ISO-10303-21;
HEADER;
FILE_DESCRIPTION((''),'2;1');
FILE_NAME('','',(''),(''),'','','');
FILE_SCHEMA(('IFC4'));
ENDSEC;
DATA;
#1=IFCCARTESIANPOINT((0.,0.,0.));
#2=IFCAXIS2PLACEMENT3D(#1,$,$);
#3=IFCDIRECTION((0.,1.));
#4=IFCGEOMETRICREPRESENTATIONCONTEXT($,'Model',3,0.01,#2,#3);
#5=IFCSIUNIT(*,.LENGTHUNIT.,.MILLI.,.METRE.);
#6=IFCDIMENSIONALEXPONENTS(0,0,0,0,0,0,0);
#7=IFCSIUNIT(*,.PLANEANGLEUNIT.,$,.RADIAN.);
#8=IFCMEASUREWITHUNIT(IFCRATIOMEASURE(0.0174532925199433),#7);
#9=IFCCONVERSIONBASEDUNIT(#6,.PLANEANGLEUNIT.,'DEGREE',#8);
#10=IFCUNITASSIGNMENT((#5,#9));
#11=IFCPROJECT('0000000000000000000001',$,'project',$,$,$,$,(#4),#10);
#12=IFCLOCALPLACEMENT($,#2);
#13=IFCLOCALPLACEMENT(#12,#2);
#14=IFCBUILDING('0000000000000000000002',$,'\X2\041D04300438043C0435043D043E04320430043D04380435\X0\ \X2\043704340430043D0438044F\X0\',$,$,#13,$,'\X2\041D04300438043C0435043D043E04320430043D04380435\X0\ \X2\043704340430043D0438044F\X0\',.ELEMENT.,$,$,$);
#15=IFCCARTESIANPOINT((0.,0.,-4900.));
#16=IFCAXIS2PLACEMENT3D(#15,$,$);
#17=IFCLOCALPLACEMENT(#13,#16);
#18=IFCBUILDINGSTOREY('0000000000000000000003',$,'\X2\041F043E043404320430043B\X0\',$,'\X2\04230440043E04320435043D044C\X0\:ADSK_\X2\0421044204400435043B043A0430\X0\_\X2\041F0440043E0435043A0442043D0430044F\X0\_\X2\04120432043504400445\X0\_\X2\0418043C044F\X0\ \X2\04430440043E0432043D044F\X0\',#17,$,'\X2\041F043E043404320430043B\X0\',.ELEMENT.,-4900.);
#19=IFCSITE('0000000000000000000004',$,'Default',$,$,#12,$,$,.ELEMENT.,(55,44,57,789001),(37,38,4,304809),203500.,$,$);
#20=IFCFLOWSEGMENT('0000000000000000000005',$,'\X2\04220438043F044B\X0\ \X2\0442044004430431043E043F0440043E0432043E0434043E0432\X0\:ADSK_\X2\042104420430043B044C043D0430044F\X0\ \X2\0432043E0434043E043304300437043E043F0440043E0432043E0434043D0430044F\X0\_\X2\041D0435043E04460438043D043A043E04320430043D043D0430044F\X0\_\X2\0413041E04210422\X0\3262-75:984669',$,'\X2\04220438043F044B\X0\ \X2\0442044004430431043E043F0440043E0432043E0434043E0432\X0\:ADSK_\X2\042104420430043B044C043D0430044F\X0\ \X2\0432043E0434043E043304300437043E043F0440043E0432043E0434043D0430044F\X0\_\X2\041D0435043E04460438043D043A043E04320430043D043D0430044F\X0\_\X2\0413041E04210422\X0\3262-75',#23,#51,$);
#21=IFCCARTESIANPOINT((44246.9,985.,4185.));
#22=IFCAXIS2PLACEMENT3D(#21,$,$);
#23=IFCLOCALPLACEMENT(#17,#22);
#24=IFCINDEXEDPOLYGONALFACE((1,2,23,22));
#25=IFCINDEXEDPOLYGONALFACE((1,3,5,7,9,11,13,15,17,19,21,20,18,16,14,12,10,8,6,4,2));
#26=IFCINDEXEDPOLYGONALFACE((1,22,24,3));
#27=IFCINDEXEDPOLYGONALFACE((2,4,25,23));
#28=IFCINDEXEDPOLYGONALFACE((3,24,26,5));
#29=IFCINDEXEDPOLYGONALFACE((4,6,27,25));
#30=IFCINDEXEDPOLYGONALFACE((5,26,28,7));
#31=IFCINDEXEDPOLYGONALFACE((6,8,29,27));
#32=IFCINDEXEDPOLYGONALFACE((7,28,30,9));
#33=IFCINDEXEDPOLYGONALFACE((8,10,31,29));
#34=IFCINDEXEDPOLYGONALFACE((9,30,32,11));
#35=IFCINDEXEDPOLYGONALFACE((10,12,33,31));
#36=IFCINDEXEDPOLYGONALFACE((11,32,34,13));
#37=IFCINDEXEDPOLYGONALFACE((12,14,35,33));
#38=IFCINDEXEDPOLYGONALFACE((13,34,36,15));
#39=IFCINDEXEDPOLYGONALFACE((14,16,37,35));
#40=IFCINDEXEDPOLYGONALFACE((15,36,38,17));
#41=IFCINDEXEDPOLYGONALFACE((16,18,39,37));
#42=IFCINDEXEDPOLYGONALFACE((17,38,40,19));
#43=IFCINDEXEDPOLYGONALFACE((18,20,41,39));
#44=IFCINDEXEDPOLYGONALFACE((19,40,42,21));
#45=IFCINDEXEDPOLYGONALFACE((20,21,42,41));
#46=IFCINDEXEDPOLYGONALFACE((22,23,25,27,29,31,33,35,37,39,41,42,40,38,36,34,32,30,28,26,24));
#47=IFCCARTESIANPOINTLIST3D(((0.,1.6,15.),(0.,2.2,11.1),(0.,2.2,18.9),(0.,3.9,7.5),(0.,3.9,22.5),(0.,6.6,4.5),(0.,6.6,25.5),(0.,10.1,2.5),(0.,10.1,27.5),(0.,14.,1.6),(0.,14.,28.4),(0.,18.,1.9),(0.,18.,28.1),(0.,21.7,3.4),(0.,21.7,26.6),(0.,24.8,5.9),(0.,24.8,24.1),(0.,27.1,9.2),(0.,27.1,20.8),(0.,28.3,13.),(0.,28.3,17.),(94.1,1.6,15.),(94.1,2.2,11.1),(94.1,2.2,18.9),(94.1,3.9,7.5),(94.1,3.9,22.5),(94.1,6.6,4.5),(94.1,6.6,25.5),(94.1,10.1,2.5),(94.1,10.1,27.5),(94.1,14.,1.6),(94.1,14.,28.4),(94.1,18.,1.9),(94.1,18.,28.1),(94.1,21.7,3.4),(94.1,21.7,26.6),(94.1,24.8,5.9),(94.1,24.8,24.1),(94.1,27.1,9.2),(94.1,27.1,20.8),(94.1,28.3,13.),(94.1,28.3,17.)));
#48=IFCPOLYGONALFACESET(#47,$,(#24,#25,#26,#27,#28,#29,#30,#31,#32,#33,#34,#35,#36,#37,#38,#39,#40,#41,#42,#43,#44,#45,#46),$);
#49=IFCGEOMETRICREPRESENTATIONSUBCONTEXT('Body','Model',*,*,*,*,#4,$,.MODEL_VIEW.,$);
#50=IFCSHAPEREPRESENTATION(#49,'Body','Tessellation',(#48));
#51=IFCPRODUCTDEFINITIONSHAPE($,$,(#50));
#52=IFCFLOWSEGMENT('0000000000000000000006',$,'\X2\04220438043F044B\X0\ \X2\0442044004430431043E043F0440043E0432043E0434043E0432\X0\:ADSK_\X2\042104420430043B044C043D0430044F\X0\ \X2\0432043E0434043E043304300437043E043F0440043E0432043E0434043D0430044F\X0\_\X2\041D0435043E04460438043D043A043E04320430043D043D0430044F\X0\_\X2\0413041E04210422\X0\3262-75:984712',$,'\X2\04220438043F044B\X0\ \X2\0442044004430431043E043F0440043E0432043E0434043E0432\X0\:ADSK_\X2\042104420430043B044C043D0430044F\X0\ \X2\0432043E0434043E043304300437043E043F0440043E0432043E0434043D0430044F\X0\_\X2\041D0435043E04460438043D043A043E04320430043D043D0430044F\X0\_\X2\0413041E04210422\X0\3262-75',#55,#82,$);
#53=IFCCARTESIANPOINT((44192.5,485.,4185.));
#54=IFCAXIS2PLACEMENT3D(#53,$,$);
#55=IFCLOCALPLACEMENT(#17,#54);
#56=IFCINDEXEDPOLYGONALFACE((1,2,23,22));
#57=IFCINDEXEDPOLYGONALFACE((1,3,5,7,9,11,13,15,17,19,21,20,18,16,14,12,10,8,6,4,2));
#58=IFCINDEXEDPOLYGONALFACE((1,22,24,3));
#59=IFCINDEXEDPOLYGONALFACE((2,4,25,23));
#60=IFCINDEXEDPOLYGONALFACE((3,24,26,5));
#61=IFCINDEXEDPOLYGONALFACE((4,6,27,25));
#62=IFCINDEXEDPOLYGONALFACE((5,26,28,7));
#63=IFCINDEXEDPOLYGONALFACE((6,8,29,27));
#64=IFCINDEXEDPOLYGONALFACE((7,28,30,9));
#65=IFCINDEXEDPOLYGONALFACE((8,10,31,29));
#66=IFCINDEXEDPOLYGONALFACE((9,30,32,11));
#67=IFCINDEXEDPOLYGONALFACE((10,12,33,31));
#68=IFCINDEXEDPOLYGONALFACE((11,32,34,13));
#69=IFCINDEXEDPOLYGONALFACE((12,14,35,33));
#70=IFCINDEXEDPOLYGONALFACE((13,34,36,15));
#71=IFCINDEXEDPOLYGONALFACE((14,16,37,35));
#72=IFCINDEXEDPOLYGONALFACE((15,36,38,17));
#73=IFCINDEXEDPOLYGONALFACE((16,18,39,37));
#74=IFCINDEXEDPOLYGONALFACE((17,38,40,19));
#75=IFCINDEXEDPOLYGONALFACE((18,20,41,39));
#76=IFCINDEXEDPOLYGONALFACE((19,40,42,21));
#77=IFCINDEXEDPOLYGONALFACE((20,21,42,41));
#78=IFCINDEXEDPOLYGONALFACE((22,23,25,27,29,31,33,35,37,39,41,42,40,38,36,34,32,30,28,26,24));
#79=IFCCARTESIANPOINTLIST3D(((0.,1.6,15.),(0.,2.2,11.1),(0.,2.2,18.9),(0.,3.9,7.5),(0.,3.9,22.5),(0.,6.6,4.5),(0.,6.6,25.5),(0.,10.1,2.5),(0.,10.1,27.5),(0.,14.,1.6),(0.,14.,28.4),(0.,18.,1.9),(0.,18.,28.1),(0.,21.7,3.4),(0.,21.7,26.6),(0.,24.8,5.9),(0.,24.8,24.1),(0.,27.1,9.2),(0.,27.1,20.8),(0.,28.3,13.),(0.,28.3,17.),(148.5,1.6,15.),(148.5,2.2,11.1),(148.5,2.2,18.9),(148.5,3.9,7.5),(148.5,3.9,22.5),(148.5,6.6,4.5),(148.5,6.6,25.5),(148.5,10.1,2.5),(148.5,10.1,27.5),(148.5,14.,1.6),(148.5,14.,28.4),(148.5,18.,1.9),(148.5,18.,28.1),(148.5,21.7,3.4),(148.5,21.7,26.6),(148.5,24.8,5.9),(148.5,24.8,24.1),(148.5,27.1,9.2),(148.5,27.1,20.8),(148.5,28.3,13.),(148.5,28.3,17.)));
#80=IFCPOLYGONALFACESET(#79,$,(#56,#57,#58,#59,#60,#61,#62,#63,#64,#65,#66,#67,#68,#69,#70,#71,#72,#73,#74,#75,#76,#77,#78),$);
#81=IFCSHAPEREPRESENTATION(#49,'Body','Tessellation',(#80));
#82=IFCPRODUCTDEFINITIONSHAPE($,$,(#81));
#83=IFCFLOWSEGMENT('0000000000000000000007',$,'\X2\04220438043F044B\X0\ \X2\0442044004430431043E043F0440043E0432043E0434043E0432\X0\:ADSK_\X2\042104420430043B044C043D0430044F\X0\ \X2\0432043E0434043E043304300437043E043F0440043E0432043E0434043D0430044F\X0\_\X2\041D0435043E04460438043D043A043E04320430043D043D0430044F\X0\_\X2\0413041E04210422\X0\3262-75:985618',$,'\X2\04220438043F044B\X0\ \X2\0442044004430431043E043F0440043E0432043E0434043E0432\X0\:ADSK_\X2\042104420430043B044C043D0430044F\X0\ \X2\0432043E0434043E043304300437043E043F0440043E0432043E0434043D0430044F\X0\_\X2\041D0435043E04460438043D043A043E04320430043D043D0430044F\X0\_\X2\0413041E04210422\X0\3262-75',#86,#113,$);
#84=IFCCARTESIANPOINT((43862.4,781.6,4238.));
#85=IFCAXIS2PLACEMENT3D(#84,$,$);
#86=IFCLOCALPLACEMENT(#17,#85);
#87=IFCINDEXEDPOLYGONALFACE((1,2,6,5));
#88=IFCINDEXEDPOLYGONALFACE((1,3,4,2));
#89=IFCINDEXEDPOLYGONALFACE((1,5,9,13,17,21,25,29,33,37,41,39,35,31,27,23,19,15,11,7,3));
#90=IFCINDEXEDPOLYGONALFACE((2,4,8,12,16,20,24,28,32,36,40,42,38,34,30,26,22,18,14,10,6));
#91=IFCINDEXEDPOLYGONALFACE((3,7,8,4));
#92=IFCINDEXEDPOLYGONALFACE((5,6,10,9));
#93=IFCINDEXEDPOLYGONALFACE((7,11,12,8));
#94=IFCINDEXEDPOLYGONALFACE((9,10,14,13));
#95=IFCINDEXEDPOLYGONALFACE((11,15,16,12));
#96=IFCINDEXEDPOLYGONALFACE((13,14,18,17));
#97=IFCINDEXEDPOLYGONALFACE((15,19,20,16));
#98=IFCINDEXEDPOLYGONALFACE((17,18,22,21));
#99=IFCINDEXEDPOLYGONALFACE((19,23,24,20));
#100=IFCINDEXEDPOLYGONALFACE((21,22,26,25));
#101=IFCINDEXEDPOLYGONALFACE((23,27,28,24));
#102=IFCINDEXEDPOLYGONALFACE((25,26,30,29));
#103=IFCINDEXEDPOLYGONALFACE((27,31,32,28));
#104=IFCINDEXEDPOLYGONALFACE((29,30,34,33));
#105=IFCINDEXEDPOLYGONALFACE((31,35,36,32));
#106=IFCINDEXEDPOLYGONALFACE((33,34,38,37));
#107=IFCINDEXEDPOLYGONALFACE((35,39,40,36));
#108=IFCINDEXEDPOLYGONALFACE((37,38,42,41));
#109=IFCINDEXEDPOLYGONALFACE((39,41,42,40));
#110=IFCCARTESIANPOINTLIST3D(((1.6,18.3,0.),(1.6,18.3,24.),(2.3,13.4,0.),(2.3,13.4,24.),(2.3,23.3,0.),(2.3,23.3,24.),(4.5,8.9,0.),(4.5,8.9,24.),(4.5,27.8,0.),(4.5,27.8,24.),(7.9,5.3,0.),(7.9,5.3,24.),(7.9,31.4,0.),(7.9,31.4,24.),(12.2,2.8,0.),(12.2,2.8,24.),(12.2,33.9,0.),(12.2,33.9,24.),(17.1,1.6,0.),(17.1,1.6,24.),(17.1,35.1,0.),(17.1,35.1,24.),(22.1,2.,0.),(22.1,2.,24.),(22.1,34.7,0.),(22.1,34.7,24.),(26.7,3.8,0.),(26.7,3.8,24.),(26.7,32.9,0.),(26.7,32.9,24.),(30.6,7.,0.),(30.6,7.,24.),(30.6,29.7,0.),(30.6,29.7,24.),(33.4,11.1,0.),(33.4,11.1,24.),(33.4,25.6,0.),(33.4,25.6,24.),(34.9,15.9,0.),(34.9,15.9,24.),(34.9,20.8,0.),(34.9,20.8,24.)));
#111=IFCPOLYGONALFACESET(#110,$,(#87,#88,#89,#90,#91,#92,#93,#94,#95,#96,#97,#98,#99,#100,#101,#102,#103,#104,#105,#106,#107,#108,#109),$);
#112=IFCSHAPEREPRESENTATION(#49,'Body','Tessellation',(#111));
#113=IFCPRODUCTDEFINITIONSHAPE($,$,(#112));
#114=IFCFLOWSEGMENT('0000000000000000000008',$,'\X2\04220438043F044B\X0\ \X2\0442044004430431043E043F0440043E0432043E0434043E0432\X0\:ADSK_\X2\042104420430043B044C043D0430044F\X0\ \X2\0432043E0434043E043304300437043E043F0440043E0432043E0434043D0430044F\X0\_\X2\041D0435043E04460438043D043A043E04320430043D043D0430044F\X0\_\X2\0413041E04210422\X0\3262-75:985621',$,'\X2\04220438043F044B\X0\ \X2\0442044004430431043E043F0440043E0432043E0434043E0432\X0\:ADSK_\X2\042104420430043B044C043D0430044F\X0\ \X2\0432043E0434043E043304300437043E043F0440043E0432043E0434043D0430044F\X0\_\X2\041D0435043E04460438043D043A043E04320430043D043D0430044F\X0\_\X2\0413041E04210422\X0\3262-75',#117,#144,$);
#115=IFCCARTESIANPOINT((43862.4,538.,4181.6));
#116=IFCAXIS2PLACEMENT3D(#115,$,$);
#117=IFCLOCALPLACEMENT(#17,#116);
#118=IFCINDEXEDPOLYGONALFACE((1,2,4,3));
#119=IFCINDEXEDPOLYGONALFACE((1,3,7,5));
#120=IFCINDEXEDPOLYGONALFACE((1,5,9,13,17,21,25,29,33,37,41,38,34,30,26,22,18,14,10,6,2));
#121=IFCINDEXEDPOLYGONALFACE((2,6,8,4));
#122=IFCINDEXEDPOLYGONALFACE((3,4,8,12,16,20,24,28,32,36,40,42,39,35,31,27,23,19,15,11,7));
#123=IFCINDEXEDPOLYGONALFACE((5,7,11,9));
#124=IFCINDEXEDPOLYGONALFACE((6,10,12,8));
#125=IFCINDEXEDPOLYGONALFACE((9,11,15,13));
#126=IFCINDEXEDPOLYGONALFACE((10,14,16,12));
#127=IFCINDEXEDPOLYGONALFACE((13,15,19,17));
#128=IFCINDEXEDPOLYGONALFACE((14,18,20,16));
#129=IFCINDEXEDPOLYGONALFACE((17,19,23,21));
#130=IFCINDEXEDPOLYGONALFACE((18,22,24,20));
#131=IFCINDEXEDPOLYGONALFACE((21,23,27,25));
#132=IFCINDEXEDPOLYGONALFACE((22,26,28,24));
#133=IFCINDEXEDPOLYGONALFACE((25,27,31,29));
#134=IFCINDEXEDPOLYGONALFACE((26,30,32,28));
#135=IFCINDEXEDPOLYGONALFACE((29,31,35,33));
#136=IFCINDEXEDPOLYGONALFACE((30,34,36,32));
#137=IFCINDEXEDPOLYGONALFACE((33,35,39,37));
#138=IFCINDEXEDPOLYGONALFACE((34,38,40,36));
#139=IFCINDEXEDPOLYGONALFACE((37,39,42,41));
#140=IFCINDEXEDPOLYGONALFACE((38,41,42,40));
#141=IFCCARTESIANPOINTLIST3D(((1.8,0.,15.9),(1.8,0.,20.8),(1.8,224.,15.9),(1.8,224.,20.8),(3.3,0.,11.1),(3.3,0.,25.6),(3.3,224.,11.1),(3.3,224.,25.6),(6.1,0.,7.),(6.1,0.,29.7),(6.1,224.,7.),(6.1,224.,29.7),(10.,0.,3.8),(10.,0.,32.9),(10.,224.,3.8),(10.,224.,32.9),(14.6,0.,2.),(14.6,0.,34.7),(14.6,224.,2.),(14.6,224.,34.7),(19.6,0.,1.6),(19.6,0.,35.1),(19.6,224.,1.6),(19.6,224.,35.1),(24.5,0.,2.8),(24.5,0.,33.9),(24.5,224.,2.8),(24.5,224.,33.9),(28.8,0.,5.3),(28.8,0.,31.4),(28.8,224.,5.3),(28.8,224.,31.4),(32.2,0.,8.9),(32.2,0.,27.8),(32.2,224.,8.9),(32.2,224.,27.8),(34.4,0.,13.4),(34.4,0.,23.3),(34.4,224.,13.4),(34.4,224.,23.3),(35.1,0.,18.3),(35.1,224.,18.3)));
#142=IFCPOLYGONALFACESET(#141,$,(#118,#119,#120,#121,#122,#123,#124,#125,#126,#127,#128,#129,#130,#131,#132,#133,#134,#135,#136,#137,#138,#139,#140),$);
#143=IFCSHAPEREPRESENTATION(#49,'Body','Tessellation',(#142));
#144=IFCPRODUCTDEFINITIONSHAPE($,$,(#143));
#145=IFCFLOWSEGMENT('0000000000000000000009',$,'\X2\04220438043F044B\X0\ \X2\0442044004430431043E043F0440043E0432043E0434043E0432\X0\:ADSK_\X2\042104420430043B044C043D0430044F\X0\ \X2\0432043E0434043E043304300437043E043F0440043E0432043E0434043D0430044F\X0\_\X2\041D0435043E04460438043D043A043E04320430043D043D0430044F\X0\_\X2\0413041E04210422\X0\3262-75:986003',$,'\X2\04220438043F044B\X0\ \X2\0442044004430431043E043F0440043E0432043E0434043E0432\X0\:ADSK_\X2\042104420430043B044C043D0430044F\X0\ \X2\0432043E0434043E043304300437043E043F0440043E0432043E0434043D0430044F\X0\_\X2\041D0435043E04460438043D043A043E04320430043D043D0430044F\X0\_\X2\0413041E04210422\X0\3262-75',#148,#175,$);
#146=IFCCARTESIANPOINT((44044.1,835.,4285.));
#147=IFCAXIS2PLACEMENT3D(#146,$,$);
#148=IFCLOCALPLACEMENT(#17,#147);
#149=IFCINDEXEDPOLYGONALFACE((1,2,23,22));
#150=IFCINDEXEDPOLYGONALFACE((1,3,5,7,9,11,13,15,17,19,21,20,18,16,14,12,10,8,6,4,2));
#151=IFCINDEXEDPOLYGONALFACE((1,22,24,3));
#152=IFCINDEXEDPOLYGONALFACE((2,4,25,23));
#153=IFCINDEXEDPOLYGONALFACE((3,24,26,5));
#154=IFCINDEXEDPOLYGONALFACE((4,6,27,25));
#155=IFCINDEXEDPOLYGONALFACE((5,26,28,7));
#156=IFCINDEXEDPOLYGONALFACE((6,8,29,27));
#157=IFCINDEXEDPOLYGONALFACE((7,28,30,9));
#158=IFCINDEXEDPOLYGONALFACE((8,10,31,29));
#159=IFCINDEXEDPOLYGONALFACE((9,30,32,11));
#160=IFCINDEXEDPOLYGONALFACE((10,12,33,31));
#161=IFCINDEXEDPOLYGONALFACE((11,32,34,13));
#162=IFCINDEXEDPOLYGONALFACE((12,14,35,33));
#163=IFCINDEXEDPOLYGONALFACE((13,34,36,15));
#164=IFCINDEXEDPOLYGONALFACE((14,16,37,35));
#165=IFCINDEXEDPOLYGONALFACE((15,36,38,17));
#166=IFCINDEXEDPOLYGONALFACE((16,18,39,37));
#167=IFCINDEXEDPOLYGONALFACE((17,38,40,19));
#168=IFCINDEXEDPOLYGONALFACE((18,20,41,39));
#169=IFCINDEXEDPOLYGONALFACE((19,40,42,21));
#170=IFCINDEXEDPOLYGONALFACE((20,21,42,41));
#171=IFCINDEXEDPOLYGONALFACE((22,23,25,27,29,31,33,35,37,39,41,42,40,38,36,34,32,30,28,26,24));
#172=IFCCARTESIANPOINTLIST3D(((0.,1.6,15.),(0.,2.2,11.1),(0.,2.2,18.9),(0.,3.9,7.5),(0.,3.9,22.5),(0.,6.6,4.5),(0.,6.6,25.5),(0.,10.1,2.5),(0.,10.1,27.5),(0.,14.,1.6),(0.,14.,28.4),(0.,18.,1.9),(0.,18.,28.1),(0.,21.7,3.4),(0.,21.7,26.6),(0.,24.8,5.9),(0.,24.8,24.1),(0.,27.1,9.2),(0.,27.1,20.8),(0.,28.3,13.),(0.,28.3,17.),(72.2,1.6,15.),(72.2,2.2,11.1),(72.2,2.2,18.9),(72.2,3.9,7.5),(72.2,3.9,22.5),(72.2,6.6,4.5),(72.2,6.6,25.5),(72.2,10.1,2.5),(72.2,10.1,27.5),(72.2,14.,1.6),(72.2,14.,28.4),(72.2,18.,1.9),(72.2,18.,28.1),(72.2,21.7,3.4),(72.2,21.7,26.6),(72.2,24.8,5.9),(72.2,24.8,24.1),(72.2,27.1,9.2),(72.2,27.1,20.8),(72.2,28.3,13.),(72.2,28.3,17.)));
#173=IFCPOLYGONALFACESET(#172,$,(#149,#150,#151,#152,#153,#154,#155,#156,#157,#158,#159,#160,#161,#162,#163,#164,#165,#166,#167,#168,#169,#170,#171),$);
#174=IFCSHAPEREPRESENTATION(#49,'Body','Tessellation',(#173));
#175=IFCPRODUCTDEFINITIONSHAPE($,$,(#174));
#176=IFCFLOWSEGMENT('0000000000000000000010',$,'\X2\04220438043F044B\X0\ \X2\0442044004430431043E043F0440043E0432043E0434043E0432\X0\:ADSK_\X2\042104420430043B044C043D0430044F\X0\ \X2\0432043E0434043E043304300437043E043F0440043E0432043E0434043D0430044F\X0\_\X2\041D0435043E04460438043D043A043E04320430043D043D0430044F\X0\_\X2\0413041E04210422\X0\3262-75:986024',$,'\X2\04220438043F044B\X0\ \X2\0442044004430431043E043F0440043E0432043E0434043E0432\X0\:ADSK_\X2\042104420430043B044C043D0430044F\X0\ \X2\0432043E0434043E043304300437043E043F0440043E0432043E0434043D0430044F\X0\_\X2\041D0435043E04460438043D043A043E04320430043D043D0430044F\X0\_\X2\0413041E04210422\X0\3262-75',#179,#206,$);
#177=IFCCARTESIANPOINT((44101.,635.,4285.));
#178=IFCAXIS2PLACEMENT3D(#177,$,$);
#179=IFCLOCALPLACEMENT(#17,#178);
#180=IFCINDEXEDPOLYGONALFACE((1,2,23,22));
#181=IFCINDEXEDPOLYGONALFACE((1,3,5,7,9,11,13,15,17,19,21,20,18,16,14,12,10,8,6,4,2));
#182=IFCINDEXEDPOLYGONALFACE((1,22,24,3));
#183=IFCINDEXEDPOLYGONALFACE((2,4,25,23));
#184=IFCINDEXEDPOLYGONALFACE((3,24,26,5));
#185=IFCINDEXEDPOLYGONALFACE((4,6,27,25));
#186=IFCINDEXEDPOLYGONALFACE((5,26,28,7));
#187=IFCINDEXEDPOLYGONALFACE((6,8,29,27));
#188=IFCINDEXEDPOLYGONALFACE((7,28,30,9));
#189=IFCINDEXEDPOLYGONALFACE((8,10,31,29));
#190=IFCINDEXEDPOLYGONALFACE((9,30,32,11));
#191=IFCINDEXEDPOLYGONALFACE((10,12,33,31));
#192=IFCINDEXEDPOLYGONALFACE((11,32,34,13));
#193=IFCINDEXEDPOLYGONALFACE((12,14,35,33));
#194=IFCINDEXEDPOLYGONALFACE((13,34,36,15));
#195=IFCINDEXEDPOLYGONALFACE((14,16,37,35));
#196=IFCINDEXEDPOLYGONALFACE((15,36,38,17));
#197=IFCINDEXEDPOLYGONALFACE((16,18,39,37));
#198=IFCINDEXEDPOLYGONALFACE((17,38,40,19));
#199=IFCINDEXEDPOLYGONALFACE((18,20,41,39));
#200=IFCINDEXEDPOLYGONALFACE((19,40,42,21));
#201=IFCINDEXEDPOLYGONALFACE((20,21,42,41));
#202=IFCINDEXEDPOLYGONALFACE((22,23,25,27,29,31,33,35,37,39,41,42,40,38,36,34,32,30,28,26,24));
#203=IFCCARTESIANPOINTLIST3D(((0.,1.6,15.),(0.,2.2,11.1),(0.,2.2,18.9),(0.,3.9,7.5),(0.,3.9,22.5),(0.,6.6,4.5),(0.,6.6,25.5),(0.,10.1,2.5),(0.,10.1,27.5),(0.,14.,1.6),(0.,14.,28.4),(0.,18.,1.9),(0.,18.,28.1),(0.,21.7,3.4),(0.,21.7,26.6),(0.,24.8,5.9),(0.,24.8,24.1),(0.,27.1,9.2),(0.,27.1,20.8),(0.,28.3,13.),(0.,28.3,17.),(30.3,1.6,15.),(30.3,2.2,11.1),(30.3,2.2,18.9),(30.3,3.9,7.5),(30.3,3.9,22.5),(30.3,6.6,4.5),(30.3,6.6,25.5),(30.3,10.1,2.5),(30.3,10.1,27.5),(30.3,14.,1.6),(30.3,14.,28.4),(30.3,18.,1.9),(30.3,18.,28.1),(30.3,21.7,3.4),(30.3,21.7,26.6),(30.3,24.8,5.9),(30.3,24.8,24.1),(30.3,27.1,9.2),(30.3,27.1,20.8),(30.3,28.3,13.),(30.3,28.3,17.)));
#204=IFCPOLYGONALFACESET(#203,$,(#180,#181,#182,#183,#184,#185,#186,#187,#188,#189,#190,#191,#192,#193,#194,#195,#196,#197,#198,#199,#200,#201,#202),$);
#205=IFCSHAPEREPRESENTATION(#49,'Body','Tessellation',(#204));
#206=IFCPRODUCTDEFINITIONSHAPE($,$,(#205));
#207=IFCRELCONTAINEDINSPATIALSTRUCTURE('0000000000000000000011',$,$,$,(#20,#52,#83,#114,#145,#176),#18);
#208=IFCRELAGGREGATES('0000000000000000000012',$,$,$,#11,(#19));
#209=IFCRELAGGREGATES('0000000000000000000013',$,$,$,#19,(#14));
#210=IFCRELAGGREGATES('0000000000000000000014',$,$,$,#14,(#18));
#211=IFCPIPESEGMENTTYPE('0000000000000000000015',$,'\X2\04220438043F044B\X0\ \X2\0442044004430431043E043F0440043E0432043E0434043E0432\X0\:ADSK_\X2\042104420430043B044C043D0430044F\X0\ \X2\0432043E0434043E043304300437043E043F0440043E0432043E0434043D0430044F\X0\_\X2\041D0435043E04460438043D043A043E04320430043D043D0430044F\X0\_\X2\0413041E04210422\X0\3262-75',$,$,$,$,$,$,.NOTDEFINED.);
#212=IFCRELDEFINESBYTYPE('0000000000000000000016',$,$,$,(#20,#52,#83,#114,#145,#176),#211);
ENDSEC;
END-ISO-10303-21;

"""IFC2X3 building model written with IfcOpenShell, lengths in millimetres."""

from ifc_helpers import new_model, entity, si_unit, converted_unit, direction, frame, origin, origin_2d_with_axis, place, context, subcontext, project, spatial, circle, extrude, type_object, element, save


model = new_model("IFC2X3")

# Units and contexts
model_context = context("Model", 3, precision=0.01, world=origin(), true_north=direction((0.0, 1.0)))
body_context = subcontext(model_context, "Body", "Model", "MODEL_VIEW")
ifc_project = project(units=[si_unit("LENGTHUNIT", "METRE", prefix="MILLI"), converted_unit("PLANEANGLEUNIT", "DEGREE", entity("IfcRatioMeasure", 0.0174532925199433), si_unit("PLANEANGLEUNIT", "RADIAN"), dimensions=[0, 0, 0, 0, 0, 0, 0])], contexts=[model_context])

# Site, building, storey
site_placement = place(None, origin())
site = spatial("IfcSite", under=ifc_project, at=site_placement, Name="Default", CompositionType="ELEMENT", RefLatitude=(55, 44, 57, 789001), RefLongitude=(37, 38, 4, 304809), RefElevation=203500.0)
building_placement = place(site_placement, origin())
building = spatial("IfcBuilding", under=site, at=building_placement, Name="Наименование здания", LongName="Наименование здания", CompositionType="ELEMENT")
storey_placement = place(building_placement, frame((0.0, 0.0, -4900.0)))
storey = spatial("IfcBuildingStorey", under=building, at=storey_placement, Name="Подвал", ObjectType="Уровень:ADSK_Стрелка_Проектная_Вверх_Имя уровня", LongName="Подвал", CompositionType="ELEMENT", Elevation=-4900.0)

# Flow segments
pipe_segment_type = type_object("IfcPipeSegmentType", Name="Типы трубопроводов:ADSK_Стальная водогазопроводная_Неоцинкованная_ГОСТ3262-75", PredefinedType="NOTDEFINED")
flow_segment_1_placement = place(storey_placement, frame((44246.9, 985.0, 4185.0)))
element("IfcFlowSegment", 1, at=flow_segment_1_placement, inside=storey, type_object=pipe_segment_type, Name="Типы трубопроводов:ADSK_Стальная водогазопроводная_Неоцинкованная_ГОСТ3262-75:984669", ObjectType="Типы трубопроводов:ADSK_Стальная водогазопроводная_Неоцинкованная_ГОСТ3262-75", context=body_context, shape_type="SweptSolid", body=[
    extrude(circle(Radius=13.4, at=origin_2d_with_axis()), frame((0.0, 15.0, 15.0), z_axis=(1.0, 0.0, 0.0), x_axis=(0.0, -1.0, 0.0)), (0.0, 0.0, 1.0), 94.1),
])
flow_segment_2_placement = place(storey_placement, frame((44192.5, 485.0, 4185.0)))
element("IfcFlowSegment", 2, at=flow_segment_2_placement, inside=storey, type_object=pipe_segment_type, Name="Типы трубопроводов:ADSK_Стальная водогазопроводная_Неоцинкованная_ГОСТ3262-75:984712", ObjectType="Типы трубопроводов:ADSK_Стальная водогазопроводная_Неоцинкованная_ГОСТ3262-75", context=body_context, shape_type="SweptSolid", body=[
    extrude(circle(Radius=13.4, at=origin_2d_with_axis()), frame((0.0, 15.0, 15.0), z_axis=(1.0, 0.0, 0.0), x_axis=(0.0, -1.0, 0.0)), (0.0, 0.0, 1.0), 148.5),
])
flow_segment_3_placement = place(storey_placement, frame((43862.4, 781.6, 4238.0)))
element("IfcFlowSegment", 3, at=flow_segment_3_placement, inside=storey, type_object=pipe_segment_type, Name="Типы трубопроводов:ADSK_Стальная водогазопроводная_Неоцинкованная_ГОСТ3262-75:985618", ObjectType="Типы трубопроводов:ADSK_Стальная водогазопроводная_Неоцинкованная_ГОСТ3262-75", context=body_context, shape_type="SweptSolid", body=[
    extrude(circle(Radius=16.8, at=origin_2d_with_axis()), frame((18.4, 18.4, 0.0), z_axis=(0.0, 0.0, 1.0), x_axis=(-1.0, 0.0, 0.0)), (0.0, 0.0, 1.0), 24.0),
])
flow_segment_4_placement = place(storey_placement, frame((43862.4, 538.0, 4181.6)))
element("IfcFlowSegment", 4, at=flow_segment_4_placement, inside=storey, type_object=pipe_segment_type, Name="Типы трубопроводов:ADSK_Стальная водогазопроводная_Неоцинкованная_ГОСТ3262-75:985621", ObjectType="Типы трубопроводов:ADSK_Стальная водогазопроводная_Неоцинкованная_ГОСТ3262-75", context=body_context, shape_type="SweptSolid", body=[
    extrude(circle(Radius=16.8, at=origin_2d_with_axis()), frame((18.4, 0.0, 18.4), z_axis=(0.0, 1.0, 0.0), x_axis=(1.0, 0.0, 0.0)), (0.0, 0.0, 1.0), 224.0),
])
flow_segment_5_placement = place(storey_placement, frame((44044.1, 835.0, 4285.0)))
element("IfcFlowSegment", 5, at=flow_segment_5_placement, inside=storey, type_object=pipe_segment_type, Name="Типы трубопроводов:ADSK_Стальная водогазопроводная_Неоцинкованная_ГОСТ3262-75:986003", ObjectType="Типы трубопроводов:ADSK_Стальная водогазопроводная_Неоцинкованная_ГОСТ3262-75", context=body_context, shape_type="SweptSolid", body=[
    extrude(circle(Radius=13.4, at=origin_2d_with_axis()), frame((0.0, 15.0, 15.0), z_axis=(1.0, 0.0, 0.0), x_axis=(0.0, -1.0, 0.0)), (0.0, 0.0, 1.0), 72.2),
])
flow_segment_6_placement = place(storey_placement, frame((44101.0, 635.0, 4285.0)))
element("IfcFlowSegment", 6, at=flow_segment_6_placement, inside=storey, type_object=pipe_segment_type, Name="Типы трубопроводов:ADSK_Стальная водогазопроводная_Неоцинкованная_ГОСТ3262-75:986024", ObjectType="Типы трубопроводов:ADSK_Стальная водогазопроводная_Неоцинкованная_ГОСТ3262-75", context=body_context, shape_type="SweptSolid", body=[
    extrude(circle(Radius=13.4, at=origin_2d_with_axis()), frame((0.0, 15.0, 15.0), z_axis=(1.0, 0.0, 0.0), x_axis=(0.0, -1.0, 0.0)), (0.0, 0.0, 1.0), 30.3),
])

save(model, "model.ifc")
